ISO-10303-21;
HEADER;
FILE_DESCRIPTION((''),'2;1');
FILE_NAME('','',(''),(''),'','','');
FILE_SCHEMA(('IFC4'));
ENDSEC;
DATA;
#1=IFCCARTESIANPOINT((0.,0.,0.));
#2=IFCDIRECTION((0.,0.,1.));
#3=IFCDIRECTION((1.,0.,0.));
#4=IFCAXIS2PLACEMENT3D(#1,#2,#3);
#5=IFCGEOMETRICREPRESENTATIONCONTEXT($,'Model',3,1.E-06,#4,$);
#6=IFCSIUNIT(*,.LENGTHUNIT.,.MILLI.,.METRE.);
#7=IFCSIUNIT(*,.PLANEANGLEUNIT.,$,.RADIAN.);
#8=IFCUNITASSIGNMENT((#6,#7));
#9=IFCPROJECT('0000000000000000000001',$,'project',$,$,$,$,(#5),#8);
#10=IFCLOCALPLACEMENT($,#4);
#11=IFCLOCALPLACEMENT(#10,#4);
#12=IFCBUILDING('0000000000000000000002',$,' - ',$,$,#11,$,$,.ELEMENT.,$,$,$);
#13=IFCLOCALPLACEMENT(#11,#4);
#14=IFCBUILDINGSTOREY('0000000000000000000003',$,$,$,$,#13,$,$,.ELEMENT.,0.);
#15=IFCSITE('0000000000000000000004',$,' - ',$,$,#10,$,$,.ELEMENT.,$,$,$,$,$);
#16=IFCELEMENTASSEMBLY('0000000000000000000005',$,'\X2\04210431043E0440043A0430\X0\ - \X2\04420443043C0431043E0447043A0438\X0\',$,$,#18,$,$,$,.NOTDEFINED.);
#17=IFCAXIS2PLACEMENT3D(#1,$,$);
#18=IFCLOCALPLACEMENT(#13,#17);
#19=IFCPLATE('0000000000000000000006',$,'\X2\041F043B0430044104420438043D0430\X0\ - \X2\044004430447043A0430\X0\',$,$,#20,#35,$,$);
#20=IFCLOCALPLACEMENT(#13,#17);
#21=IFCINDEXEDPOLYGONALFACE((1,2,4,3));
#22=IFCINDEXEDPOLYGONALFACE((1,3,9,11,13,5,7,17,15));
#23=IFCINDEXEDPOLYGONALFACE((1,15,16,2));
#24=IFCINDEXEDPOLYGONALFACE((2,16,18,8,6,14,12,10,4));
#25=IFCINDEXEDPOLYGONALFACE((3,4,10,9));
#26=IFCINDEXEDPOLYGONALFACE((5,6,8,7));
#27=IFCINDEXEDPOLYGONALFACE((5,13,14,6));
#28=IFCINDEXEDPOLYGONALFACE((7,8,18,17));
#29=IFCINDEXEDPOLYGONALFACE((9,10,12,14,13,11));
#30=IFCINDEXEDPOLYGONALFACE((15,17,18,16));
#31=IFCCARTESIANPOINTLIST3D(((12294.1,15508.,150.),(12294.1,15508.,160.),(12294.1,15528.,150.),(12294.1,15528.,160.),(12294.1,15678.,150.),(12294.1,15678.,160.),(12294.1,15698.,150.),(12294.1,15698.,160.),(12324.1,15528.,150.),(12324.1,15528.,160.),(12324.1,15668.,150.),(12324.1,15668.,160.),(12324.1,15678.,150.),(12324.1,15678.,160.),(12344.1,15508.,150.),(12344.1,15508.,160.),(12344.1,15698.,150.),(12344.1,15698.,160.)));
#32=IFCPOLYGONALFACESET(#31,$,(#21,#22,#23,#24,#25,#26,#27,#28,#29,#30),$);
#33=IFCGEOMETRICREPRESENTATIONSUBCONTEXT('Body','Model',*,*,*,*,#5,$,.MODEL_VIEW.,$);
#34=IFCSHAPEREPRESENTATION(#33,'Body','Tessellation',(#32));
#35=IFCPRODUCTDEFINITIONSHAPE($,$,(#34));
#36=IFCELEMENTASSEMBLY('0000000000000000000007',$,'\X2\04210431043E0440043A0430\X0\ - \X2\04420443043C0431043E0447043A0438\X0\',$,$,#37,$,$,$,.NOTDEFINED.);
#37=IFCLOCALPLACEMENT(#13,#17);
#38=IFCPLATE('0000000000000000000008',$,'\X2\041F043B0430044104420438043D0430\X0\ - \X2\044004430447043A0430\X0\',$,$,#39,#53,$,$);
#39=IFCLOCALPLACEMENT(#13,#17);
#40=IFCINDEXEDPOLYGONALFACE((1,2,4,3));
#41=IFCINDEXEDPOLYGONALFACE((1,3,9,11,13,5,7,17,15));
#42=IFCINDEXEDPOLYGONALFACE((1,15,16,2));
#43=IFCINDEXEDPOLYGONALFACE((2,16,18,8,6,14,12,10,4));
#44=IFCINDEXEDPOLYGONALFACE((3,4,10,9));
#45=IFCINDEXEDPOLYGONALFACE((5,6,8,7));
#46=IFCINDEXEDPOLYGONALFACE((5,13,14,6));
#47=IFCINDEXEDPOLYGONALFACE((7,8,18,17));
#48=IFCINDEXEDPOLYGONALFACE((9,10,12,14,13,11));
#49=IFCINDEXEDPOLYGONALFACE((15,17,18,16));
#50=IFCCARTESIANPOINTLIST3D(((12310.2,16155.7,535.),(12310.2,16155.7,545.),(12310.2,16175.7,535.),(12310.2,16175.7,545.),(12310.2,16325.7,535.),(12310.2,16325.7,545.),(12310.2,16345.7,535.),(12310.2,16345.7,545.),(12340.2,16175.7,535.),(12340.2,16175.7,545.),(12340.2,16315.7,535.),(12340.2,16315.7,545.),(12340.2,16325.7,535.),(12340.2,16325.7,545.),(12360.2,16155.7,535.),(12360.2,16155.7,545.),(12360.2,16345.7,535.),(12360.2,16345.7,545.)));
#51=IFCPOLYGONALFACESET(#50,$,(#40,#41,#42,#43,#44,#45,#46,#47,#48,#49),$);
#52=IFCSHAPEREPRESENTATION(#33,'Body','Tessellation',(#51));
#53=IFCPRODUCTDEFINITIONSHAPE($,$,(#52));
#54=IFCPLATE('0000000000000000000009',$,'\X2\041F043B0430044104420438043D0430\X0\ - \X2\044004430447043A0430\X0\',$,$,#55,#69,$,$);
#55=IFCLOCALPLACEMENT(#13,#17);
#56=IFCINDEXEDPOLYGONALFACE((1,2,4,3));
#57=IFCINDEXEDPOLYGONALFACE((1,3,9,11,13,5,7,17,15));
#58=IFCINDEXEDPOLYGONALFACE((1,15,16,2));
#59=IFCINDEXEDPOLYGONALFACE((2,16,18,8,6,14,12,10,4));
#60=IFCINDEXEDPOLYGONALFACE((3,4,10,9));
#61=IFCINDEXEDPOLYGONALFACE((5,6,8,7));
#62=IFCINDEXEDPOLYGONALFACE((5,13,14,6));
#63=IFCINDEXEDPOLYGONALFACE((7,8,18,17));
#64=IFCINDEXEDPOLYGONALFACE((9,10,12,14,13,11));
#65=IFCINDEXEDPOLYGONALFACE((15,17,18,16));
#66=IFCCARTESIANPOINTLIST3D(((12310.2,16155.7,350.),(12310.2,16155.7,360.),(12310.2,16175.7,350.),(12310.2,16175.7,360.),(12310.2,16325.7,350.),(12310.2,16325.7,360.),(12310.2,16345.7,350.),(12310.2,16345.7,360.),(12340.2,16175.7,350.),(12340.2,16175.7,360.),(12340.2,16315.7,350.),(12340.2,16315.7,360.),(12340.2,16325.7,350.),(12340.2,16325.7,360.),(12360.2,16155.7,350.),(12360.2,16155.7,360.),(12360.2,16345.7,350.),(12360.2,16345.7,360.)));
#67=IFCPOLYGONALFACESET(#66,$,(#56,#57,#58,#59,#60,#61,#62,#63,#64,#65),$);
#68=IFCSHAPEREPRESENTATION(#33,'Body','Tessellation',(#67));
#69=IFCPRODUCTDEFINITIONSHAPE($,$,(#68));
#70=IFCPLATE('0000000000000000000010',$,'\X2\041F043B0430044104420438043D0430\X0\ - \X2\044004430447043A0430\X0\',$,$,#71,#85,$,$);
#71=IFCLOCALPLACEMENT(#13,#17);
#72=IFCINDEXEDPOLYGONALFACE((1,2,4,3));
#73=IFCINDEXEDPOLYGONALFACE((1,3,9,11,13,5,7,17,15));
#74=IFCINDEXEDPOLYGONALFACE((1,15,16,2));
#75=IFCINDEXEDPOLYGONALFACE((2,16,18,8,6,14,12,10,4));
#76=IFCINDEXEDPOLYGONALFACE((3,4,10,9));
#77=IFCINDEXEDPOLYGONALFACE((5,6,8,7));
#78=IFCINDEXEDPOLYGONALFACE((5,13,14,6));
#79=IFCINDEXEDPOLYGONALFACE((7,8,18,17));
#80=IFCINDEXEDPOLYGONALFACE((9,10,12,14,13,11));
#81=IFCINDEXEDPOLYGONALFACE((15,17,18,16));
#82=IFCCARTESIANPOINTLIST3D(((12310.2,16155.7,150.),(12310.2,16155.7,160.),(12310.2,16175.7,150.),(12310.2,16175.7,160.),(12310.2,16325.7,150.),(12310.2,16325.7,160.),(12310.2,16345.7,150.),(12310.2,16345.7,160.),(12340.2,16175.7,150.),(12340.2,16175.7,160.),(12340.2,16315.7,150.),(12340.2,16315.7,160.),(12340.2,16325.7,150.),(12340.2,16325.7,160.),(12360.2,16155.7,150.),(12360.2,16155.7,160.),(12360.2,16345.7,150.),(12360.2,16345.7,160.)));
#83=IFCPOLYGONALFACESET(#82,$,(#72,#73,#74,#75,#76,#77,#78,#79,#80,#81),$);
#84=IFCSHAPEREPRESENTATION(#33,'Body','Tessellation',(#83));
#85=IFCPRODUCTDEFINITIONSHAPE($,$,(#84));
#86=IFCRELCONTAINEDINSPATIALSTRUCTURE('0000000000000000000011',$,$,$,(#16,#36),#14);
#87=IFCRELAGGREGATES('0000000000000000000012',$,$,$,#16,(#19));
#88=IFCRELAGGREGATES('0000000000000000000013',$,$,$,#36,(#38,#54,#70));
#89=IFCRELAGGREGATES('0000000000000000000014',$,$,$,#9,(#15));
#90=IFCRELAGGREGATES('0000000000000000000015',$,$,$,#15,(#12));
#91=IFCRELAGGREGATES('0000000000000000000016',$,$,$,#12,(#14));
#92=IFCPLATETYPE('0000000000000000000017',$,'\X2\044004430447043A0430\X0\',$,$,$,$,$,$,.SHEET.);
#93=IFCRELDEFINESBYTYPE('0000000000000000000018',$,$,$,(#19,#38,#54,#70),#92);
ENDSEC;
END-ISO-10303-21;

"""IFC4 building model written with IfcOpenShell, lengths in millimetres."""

from ifc_helpers import new_model, si_unit, frame, origin_with_axes, place, context, subcontext, project, spatial, line, indexed_curve, outline, extrude, source, transform, mapped, type_object, element, aggregate, save


model = new_model("IFC4")

# Units and contexts
model_context = context("Model", 3, precision=1e-06, world=origin_with_axes())
body_context = subcontext(model_context, "Body", "Model", "MODEL_VIEW")
ifc_project = project(units=[si_unit("LENGTHUNIT", "METRE", prefix="MILLI"), si_unit("PLANEANGLEUNIT", "RADIAN")], contexts=[model_context])

# Site, building, storey
site_placement = place(None, origin_with_axes())
site = spatial("IfcSite", under=ifc_project, at=site_placement, Name=" - ", CompositionType="ELEMENT")
building_placement = place(site_placement, origin_with_axes())
building = spatial("IfcBuilding", under=site, at=building_placement, Name=" - ", CompositionType="ELEMENT")
storey_placement = place(building_placement, origin_with_axes())
storey = spatial("IfcBuildingStorey", under=building, at=storey_placement, CompositionType="ELEMENT", Elevation=0.0)

# Element assemblies, plates
plate_type = type_object("IfcPlateType", Name="ручка", PredefinedType="SHEET")
shared_shape = source(origin_with_axes(), body_context, "Body", "SweptSolid", [
    extrude(outline(indexed_curve([(-95.0, -25.0), (-75.0, -25.0), (-75.0, 5.0), (-65.0, 5.0), (75.0, 5.0), (75.0, -25.0), (95.0, -25.0), (95.0, 25.0), (-95.0, 25.0)], segments=[line(1, 2), line(2, 3), line(3, 4), line(4, 5), line(5, 6), line(6, 7), line(7, 8), line(8, 9), line(9, 1)])), origin_with_axes(), (0.0, 0.0, 1.0), 10.0),
])
assembly_1_placement = place(storey_placement, frame((12294.1, 15403.0, 0.0), z_axis=(0.0, 0.0, 1.0), x_axis=(0.0, 1.0, 0.0)))
assembly_1 = element("IfcElementAssembly", 1, at=assembly_1_placement, inside=storey, Name="Сборка - тумбочки", PredefinedType="NOTDEFINED")
plate_1_placement = place(assembly_1_placement, frame((200.0, -25.0, 150.0), z_axis=(0.0, 0.0, 1.0), x_axis=(-1.0, 0.0, 0.0)))
plate_1 = element("IfcPlate", 2, at=plate_1_placement, type_object=plate_type, Name="Пластина - ручка", context=body_context, shape_type="MappedRepresentation", body=[
    mapped(shared_shape, transform((0.0, 0.0, 0.0), x_axis=(1.0, 0.0, 0.0), y_axis=(0.0, 1.0, 0.0), z_axis=(0.0, 0.0, 1.0), scale=1.0)),
])
aggregate(assembly_1, [plate_1])
assembly_2_placement = place(storey_placement, frame((12310.2, 16050.7, 0.0), z_axis=(0.0, 0.0, 1.0), x_axis=(0.0, 1.0, 0.0)))
assembly_2 = element("IfcElementAssembly", 3, at=assembly_2_placement, inside=storey, Name="Сборка - тумбочки", PredefinedType="NOTDEFINED")
plate_2_placement = place(assembly_2_placement, frame((200.0, -25.0, 535.0), z_axis=(0.0, 0.0, 1.0), x_axis=(-1.0, 0.0, 0.0)))
plate_2 = element("IfcPlate", 4, at=plate_2_placement, type_object=plate_type, Name="Пластина - ручка", context=body_context, shape_type="MappedRepresentation", body=[
    mapped(shared_shape, transform((0.0, 0.0, 0.0), x_axis=(1.0, 0.0, 0.0), y_axis=(0.0, 1.0, 0.0), z_axis=(0.0, 0.0, 1.0), scale=1.0)),
])
plate_3_placement = place(assembly_2_placement, frame((200.0, -25.0, 350.0), z_axis=(0.0, 0.0, 1.0), x_axis=(-1.0, 0.0, 0.0)))
plate_3 = element("IfcPlate", 5, at=plate_3_placement, type_object=plate_type, Name="Пластина - ручка", context=body_context, shape_type="MappedRepresentation", body=[
    mapped(shared_shape, transform((0.0, 0.0, 0.0), x_axis=(1.0, 0.0, 0.0), y_axis=(0.0, 1.0, 0.0), z_axis=(0.0, 0.0, 1.0), scale=1.0)),
])
plate_4_placement = place(assembly_2_placement, frame((200.0, -25.0, 150.0), z_axis=(0.0, 0.0, 1.0), x_axis=(-1.0, 0.0, 0.0)))
plate_4 = element("IfcPlate", 6, at=plate_4_placement, type_object=plate_type, Name="Пластина - ручка", context=body_context, shape_type="MappedRepresentation", body=[
    mapped(shared_shape, transform((0.0, 0.0, 0.0), x_axis=(1.0, 0.0, 0.0), y_axis=(0.0, 1.0, 0.0), z_axis=(0.0, 0.0, 1.0), scale=1.0)),
])
aggregate(assembly_2, [plate_2, plate_3, plate_4])

save(model, "model.ifc")
